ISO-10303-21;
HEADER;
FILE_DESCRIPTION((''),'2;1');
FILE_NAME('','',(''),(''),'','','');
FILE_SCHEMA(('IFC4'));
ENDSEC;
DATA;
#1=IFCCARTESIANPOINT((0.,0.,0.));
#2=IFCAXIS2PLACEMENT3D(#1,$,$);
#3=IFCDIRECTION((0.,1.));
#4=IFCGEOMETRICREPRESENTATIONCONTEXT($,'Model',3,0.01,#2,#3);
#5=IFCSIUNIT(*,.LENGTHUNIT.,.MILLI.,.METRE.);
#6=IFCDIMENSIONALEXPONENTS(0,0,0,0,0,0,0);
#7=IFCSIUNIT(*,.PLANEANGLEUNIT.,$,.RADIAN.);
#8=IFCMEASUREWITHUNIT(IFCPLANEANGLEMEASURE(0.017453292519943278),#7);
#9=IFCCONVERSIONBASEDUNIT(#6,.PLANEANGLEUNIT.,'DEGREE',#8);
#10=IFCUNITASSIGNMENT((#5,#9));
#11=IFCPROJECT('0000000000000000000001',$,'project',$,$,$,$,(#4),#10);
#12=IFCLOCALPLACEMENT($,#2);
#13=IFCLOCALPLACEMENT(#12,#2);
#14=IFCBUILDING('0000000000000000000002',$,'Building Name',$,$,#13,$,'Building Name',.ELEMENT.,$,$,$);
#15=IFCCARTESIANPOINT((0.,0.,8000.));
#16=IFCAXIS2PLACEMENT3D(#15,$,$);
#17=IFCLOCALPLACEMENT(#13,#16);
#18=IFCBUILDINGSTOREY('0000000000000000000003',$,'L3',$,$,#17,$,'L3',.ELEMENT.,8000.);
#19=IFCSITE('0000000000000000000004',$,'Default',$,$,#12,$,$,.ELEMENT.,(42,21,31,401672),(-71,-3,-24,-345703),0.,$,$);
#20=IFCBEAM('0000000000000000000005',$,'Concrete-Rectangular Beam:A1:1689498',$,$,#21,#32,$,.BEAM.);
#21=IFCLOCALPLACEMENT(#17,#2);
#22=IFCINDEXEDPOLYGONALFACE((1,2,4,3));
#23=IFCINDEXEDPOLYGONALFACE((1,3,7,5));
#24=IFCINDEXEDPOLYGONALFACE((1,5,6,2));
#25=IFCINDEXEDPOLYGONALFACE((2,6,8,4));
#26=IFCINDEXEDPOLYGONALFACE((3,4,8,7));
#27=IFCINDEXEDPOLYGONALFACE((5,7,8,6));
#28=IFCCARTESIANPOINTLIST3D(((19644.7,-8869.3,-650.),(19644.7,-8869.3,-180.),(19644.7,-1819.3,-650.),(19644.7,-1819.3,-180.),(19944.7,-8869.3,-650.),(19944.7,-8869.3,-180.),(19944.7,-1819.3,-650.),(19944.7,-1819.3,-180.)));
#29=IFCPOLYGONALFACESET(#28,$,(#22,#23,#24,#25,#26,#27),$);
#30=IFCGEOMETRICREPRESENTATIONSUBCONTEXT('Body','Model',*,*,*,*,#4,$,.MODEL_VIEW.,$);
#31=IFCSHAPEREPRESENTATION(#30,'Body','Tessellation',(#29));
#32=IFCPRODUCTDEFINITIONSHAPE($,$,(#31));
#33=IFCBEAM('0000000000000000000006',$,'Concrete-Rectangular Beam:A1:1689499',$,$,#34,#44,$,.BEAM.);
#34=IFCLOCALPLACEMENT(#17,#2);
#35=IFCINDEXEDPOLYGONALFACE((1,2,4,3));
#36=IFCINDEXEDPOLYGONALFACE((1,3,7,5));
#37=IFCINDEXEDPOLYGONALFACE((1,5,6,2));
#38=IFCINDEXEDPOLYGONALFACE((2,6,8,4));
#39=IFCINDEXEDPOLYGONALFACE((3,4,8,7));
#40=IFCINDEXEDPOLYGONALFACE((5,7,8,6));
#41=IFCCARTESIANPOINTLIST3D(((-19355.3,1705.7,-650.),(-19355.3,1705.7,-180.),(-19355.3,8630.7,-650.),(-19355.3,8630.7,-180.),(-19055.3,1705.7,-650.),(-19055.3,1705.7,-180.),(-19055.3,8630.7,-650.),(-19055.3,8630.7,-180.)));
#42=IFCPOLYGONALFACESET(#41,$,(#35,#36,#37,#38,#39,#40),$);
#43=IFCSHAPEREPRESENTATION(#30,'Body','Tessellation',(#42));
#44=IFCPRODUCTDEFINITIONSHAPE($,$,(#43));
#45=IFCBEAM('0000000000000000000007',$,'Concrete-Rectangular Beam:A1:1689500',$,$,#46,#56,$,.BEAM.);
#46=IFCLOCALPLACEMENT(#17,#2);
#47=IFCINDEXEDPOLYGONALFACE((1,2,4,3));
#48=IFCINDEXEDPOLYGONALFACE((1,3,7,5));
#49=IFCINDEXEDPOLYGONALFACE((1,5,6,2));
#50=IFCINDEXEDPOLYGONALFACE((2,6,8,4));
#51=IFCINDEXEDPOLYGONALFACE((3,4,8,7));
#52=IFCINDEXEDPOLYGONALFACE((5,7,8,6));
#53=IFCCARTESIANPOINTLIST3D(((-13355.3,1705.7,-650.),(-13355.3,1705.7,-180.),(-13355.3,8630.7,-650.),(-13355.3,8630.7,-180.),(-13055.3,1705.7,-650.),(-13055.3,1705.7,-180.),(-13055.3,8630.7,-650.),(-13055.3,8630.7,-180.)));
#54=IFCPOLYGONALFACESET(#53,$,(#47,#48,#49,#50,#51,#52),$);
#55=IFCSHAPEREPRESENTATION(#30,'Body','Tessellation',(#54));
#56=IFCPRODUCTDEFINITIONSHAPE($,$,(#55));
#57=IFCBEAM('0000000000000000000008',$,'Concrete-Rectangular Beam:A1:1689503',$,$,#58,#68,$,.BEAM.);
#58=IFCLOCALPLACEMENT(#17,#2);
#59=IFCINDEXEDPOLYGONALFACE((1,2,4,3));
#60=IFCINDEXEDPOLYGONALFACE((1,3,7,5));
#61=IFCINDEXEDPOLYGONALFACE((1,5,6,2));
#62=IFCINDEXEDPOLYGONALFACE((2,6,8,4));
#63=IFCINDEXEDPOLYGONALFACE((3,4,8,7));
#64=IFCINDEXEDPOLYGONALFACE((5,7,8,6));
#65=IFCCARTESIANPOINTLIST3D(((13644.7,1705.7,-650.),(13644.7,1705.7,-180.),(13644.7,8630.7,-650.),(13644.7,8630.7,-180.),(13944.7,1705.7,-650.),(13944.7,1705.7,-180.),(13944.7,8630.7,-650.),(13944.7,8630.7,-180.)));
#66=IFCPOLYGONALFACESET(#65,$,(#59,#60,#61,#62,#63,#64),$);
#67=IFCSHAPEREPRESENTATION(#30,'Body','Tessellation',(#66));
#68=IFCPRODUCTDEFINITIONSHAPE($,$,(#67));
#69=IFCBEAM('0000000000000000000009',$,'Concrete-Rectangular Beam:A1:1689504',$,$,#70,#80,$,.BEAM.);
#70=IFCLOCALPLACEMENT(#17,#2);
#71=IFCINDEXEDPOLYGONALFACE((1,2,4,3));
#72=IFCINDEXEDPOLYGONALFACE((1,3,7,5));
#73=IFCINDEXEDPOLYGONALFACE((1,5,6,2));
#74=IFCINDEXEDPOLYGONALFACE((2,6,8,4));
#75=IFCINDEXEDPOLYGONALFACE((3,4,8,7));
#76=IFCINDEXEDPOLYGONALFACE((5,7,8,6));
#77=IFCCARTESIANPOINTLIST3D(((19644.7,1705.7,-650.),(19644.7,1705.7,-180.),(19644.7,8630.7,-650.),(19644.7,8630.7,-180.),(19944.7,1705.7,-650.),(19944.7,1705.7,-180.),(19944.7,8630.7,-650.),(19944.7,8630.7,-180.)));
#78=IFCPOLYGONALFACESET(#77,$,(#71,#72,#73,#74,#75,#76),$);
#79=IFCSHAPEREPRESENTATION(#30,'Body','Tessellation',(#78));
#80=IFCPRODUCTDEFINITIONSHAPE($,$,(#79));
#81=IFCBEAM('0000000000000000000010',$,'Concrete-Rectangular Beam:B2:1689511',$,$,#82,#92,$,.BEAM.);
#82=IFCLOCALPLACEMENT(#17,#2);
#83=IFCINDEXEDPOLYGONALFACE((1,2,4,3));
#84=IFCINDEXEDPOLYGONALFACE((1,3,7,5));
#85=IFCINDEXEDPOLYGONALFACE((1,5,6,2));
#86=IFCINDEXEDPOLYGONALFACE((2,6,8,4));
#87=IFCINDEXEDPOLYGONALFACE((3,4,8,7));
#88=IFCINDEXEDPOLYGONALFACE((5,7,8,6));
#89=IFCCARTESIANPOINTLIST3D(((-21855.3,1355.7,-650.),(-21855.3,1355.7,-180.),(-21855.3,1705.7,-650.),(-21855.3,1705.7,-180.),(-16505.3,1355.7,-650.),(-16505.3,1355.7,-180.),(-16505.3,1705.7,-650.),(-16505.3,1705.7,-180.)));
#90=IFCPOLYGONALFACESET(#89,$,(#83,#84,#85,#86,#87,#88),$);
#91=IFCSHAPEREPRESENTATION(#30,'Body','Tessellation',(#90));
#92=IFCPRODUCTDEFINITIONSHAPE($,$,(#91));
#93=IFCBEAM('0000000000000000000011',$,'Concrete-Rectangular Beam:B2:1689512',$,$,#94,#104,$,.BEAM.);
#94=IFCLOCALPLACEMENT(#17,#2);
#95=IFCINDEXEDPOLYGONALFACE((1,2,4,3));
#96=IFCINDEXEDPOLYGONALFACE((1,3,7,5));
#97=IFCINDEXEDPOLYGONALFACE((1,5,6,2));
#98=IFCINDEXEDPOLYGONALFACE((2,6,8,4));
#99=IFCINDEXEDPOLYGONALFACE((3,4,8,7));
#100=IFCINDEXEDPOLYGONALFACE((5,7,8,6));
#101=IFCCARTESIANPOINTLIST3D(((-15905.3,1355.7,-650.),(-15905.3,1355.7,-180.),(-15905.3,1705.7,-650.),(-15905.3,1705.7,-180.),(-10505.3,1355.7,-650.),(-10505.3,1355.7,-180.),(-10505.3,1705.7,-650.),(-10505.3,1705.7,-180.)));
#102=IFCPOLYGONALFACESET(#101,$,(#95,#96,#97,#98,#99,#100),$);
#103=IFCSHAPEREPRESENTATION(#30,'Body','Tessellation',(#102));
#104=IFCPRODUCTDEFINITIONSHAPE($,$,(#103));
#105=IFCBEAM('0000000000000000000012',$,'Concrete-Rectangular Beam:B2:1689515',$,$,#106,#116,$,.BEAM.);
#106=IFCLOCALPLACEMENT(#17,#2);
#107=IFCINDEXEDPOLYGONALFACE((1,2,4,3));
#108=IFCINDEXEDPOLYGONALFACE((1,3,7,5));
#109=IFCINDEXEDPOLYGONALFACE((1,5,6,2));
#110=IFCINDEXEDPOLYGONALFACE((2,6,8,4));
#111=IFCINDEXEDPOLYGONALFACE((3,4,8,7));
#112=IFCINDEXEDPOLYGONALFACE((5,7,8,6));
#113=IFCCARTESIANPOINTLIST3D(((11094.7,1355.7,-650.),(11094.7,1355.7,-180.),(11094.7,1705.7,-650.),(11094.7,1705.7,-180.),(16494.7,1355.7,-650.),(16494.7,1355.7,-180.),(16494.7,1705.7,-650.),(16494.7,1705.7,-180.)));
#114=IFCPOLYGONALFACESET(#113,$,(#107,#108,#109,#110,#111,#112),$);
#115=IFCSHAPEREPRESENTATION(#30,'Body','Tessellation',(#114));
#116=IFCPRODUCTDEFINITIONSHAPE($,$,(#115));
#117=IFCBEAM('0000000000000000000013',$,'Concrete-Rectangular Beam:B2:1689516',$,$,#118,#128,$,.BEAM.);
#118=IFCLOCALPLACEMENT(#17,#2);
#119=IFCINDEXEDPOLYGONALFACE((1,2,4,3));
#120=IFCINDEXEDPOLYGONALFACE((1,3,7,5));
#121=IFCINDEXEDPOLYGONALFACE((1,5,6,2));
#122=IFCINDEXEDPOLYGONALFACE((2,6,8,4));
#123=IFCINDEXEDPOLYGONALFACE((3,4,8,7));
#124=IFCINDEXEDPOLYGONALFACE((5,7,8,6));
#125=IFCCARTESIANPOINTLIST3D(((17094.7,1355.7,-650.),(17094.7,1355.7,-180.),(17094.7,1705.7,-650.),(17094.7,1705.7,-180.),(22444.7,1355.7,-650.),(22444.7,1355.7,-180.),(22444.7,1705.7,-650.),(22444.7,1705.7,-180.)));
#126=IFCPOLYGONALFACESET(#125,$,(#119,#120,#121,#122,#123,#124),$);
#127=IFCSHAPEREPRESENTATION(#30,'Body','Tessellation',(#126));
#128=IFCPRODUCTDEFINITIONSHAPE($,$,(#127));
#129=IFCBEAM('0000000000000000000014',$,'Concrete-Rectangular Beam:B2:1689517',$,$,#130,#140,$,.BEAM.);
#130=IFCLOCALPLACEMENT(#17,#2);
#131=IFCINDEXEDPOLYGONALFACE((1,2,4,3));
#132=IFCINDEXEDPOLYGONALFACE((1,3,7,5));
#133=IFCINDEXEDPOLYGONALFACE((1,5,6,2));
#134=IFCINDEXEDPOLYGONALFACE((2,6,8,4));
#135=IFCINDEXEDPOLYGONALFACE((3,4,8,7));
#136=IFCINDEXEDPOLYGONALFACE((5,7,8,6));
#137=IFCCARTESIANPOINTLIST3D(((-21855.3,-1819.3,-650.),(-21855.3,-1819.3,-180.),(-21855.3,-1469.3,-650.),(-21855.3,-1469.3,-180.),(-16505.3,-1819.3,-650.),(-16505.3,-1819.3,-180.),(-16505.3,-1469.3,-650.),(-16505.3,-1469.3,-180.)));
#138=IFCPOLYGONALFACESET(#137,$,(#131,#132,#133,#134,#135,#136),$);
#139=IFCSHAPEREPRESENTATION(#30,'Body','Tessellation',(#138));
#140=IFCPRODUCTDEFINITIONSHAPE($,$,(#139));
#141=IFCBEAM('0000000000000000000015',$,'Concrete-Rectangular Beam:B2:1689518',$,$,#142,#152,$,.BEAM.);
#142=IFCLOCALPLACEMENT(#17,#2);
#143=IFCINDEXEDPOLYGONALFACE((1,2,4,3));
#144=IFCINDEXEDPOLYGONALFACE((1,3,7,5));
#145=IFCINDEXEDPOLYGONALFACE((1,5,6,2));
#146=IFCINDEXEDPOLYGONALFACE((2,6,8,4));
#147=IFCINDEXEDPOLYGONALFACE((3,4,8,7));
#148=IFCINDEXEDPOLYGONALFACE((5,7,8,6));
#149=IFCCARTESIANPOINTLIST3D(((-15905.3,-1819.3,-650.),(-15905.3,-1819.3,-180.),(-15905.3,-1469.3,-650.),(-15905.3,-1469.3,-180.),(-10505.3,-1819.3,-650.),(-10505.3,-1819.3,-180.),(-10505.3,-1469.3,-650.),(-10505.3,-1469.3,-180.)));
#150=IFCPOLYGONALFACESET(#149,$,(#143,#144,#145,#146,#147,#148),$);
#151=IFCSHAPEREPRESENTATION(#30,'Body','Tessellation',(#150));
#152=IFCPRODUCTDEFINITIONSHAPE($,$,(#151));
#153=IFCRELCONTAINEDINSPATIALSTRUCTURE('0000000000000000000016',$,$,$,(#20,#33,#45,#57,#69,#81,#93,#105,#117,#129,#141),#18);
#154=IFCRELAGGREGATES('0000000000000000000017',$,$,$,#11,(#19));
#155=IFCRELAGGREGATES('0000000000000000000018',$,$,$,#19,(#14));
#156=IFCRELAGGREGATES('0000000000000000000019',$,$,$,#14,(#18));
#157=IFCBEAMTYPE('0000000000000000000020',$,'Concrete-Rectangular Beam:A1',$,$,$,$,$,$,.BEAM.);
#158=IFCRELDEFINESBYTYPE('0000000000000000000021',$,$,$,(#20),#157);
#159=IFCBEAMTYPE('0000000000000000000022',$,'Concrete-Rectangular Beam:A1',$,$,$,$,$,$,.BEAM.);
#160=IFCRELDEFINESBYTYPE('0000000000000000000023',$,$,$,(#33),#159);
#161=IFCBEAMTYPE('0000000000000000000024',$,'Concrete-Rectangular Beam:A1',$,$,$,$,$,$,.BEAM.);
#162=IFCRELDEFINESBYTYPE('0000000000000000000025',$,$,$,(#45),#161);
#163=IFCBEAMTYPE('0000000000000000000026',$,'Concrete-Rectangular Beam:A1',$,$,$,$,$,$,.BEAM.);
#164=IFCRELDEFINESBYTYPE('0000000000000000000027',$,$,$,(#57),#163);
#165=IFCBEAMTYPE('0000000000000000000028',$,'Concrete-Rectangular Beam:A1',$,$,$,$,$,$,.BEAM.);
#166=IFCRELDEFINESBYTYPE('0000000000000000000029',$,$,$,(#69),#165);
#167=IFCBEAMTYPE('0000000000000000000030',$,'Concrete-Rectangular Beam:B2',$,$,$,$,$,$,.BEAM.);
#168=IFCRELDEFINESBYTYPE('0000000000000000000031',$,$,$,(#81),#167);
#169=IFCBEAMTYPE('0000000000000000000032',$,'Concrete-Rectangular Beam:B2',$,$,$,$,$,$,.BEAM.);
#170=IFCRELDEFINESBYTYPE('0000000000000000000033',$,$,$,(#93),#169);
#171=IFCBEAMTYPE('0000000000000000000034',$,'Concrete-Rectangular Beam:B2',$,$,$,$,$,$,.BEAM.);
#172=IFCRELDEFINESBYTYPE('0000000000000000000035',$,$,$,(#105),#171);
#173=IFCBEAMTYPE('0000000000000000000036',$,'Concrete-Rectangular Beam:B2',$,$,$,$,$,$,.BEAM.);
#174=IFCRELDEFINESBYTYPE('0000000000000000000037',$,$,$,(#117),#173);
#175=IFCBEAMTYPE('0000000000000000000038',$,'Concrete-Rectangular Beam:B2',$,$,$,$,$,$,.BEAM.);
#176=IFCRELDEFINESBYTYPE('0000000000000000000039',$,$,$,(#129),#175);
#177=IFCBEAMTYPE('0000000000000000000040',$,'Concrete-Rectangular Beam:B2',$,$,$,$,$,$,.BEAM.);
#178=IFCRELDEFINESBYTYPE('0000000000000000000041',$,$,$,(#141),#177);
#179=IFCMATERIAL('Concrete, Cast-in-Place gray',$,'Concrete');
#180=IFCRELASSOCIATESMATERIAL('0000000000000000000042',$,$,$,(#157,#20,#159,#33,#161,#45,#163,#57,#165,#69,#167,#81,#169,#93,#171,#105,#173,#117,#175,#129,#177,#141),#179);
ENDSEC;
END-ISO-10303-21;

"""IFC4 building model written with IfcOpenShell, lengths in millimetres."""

from ifc_helpers import new_model, entity, si_unit, converted_unit, direction, frame, origin, place, context, subcontext, project, spatial, indexed_curve, outline, extrude, source, transform, mapped, material, type_object, type_shapes, element, save


model = new_model("IFC4")

# Units and contexts
model_context = context("Model", 3, precision=0.01, world=origin(), true_north=direction((0.0, 1.0)))
body_context = subcontext(model_context, "Body", "Model", "MODEL_VIEW")
ifc_project = project(units=[si_unit("LENGTHUNIT", "METRE", prefix="MILLI"), converted_unit("PLANEANGLEUNIT", "DEGREE", entity("IfcPlaneAngleMeasure", 0.017453292519943278), si_unit("PLANEANGLEUNIT", "RADIAN"), dimensions=[0, 0, 0, 0, 0, 0, 0])], contexts=[model_context])

# Site, building, storey
site_placement = place(None, origin())
site = spatial("IfcSite", under=ifc_project, at=site_placement, Name="Default", CompositionType="ELEMENT", RefLatitude=(42, 21, 31, 401672), RefLongitude=(-71, -3, -24, -345703), RefElevation=0.0)
building_placement = place(site_placement, origin())
building = spatial("IfcBuilding", under=site, at=building_placement, Name="Building Name", LongName="Building Name", CompositionType="ELEMENT")
storey_placement = place(building_placement, frame((0.0, 0.0, 8000.0)))
storey = spatial("IfcBuildingStorey", under=building, at=storey_placement, Name="L3", LongName="L3", CompositionType="ELEMENT", Elevation=8000.0)

# Beams
ifc_material = material(Name="Concrete, Cast-in-Place gray", Category="Concrete")
beam_type_1 = type_object("IfcBeamType", Name="Concrete-Rectangular Beam:A1", PredefinedType="BEAM", material=ifc_material)
shared_shape_1 = source(origin(), body_context, "Body", "SweptSolid", [
    extrude(outline(indexed_curve([(-150.0, -235.0), (150.0, -235.0), (150.0, 235.0), (-150.0, 235.0), (-150.0, -235.0)], self_intersect=False)), frame((19794.7, -8869.3, 7585.0), z_axis=(0.0, 1.0, 0.0), x_axis=(-1.0, 0.0, 0.0)), (0.0, 0.0, 1.0), 7050.0),
])
type_shapes(beam_type_1, [shared_shape_1])
beam_1_placement = place(storey_placement, frame((0.0, 0.0, -8000.0)))
element("IfcBeam", 1, at=beam_1_placement, inside=storey, type_object=beam_type_1, material=ifc_material, Name="Concrete-Rectangular Beam:A1:1689498", PredefinedType="BEAM", context=body_context, shape_type="MappedRepresentation", body=[
    mapped(shared_shape_1, transform((0.0, 0.0, 0.0), scale=1.0)),
])
beam_type_2 = type_object("IfcBeamType", Name="Concrete-Rectangular Beam:A1", PredefinedType="BEAM", material=ifc_material)
shared_shape_2 = source(origin(), body_context, "Body", "SweptSolid", [
    extrude(outline(indexed_curve([(-150.0, -235.0), (150.0, -235.0), (150.0, 235.0), (-150.0, 235.0), (-150.0, -235.0)], self_intersect=False)), frame((-19205.3, 8630.7, 7585.0), z_axis=(0.0, -1.0, 0.0), x_axis=(-1.0, 0.0, 0.0)), (0.0, 0.0, 1.0), 6925.0),
])
type_shapes(beam_type_2, [shared_shape_2])
beam_2_placement = place(storey_placement, frame((0.0, 0.0, -8000.0)))
element("IfcBeam", 2, at=beam_2_placement, inside=storey, type_object=beam_type_2, material=ifc_material, Name="Concrete-Rectangular Beam:A1:1689499", PredefinedType="BEAM", context=body_context, shape_type="MappedRepresentation", body=[
    mapped(shared_shape_2, transform((0.0, 0.0, 0.0), scale=1.0)),
])
beam_type_3 = type_object("IfcBeamType", Name="Concrete-Rectangular Beam:A1", PredefinedType="BEAM", material=ifc_material)
shared_shape_3 = source(origin(), body_context, "Body", "SweptSolid", [
    extrude(outline(indexed_curve([(-150.0, -235.0), (150.0, -235.0), (150.0, 235.0), (-150.0, 235.0), (-150.0, -235.0)], self_intersect=False)), frame((-13205.3, 8630.7, 7585.0), z_axis=(0.0, -1.0, 0.0), x_axis=(-1.0, 0.0, 0.0)), (0.0, 0.0, 1.0), 6925.0),
])
type_shapes(beam_type_3, [shared_shape_3])
beam_3_placement = place(storey_placement, frame((0.0, 0.0, -8000.0)))
element("IfcBeam", 3, at=beam_3_placement, inside=storey, type_object=beam_type_3, material=ifc_material, Name="Concrete-Rectangular Beam:A1:1689500", PredefinedType="BEAM", context=body_context, shape_type="MappedRepresentation", body=[
    mapped(shared_shape_3, transform((0.0, 0.0, 0.0), scale=1.0)),
])
beam_type_4 = type_object("IfcBeamType", Name="Concrete-Rectangular Beam:A1", PredefinedType="BEAM", material=ifc_material)
shared_shape_4 = source(origin(), body_context, "Body", "SweptSolid", [
    extrude(outline(indexed_curve([(-150.0, -235.0), (150.0, -235.0), (150.0, 235.0), (-150.0, 235.0), (-150.0, -235.0)], self_intersect=False)), frame((13794.7, 8630.7, 7585.0), z_axis=(0.0, -1.0, 0.0), x_axis=(-1.0, 0.0, 0.0)), (0.0, 0.0, 1.0), 6925.0),
])
type_shapes(beam_type_4, [shared_shape_4])
beam_4_placement = place(storey_placement, frame((0.0, 0.0, -8000.0)))
element("IfcBeam", 4, at=beam_4_placement, inside=storey, type_object=beam_type_4, material=ifc_material, Name="Concrete-Rectangular Beam:A1:1689503", PredefinedType="BEAM", context=body_context, shape_type="MappedRepresentation", body=[
    mapped(shared_shape_4, transform((0.0, 0.0, 0.0), scale=1.0)),
])
beam_type_5 = type_object("IfcBeamType", Name="Concrete-Rectangular Beam:A1", PredefinedType="BEAM", material=ifc_material)
shared_shape_5 = source(origin(), body_context, "Body", "SweptSolid", [
    extrude(outline(indexed_curve([(-150.0, -235.0), (150.0, -235.0), (150.0, 235.0), (-150.0, 235.0), (-150.0, -235.0)], self_intersect=False)), frame((19794.7, 8630.7, 7585.0), z_axis=(0.0, -1.0, 0.0), x_axis=(-1.0, 0.0, 0.0)), (0.0, 0.0, 1.0), 6925.0),
])
type_shapes(beam_type_5, [shared_shape_5])
beam_5_placement = place(storey_placement, frame((0.0, 0.0, -8000.0)))
element("IfcBeam", 5, at=beam_5_placement, inside=storey, type_object=beam_type_5, material=ifc_material, Name="Concrete-Rectangular Beam:A1:1689504", PredefinedType="BEAM", context=body_context, shape_type="MappedRepresentation", body=[
    mapped(shared_shape_5, transform((0.0, 0.0, 0.0), scale=1.0)),
])
beam_type_6 = type_object("IfcBeamType", Name="Concrete-Rectangular Beam:B2", PredefinedType="BEAM", material=ifc_material)
shared_shape_6 = source(origin(), body_context, "Body", "SweptSolid", [
    extrude(outline(indexed_curve([(-235.0, -175.0), (235.0, -175.0), (235.0, 175.0), (-235.0, 175.0), (-235.0, -175.0)], self_intersect=False)), frame((-21855.3, 1530.7, 7585.0), z_axis=(1.0, 0.0, 0.0), x_axis=(0.0, 0.0, -1.0)), (0.0, 0.0, 1.0), 5350.0),
])
type_shapes(beam_type_6, [shared_shape_6])
beam_6_placement = place(storey_placement, frame((0.0, 0.0, -8000.0)))
element("IfcBeam", 6, at=beam_6_placement, inside=storey, type_object=beam_type_6, material=ifc_material, Name="Concrete-Rectangular Beam:B2:1689511", PredefinedType="BEAM", context=body_context, shape_type="MappedRepresentation", body=[
    mapped(shared_shape_6, transform((0.0, 0.0, 0.0), scale=1.0)),
])
beam_type_7 = type_object("IfcBeamType", Name="Concrete-Rectangular Beam:B2", PredefinedType="BEAM", material=ifc_material)
shared_shape_7 = source(origin(), body_context, "Body", "SweptSolid", [
    extrude(outline(indexed_curve([(-235.0, -175.0), (235.0, -175.0), (235.0, 175.0), (-235.0, 175.0), (-235.0, -175.0)], self_intersect=False)), frame((-15905.3, 1530.7, 7585.0), z_axis=(1.0, 0.0, 0.0), x_axis=(0.0, 0.0, -1.0)), (0.0, 0.0, 1.0), 5400.0),
])
type_shapes(beam_type_7, [shared_shape_7])
beam_7_placement = place(storey_placement, frame((0.0, 0.0, -8000.0)))
element("IfcBeam", 7, at=beam_7_placement, inside=storey, type_object=beam_type_7, material=ifc_material, Name="Concrete-Rectangular Beam:B2:1689512", PredefinedType="BEAM", context=body_context, shape_type="MappedRepresentation", body=[
    mapped(shared_shape_7, transform((0.0, 0.0, 0.0), scale=1.0)),
])
beam_type_8 = type_object("IfcBeamType", Name="Concrete-Rectangular Beam:B2", PredefinedType="BEAM", material=ifc_material)
shared_shape_8 = source(origin(), body_context, "Body", "SweptSolid", [
    extrude(outline(indexed_curve([(-235.0, -175.0), (235.0, -175.0), (235.0, 175.0), (-235.0, 175.0), (-235.0, -175.0)], self_intersect=False)), frame((11094.7, 1530.7, 7585.0), z_axis=(1.0, 0.0, 0.0), x_axis=(0.0, 0.0, -1.0)), (0.0, 0.0, 1.0), 5400.0),
])
type_shapes(beam_type_8, [shared_shape_8])
beam_8_placement = place(storey_placement, frame((0.0, 0.0, -8000.0)))
element("IfcBeam", 8, at=beam_8_placement, inside=storey, type_object=beam_type_8, material=ifc_material, Name="Concrete-Rectangular Beam:B2:1689515", PredefinedType="BEAM", context=body_context, shape_type="MappedRepresentation", body=[
    mapped(shared_shape_8, transform((0.0, 0.0, 0.0), scale=1.0)),
])
beam_type_9 = type_object("IfcBeamType", Name="Concrete-Rectangular Beam:B2", PredefinedType="BEAM", material=ifc_material)
shared_shape_9 = source(origin(), body_context, "Body", "SweptSolid", [
    extrude(outline(indexed_curve([(-235.0, -175.0), (235.0, -175.0), (235.0, 175.0), (-235.0, 175.0), (-235.0, -175.0)], self_intersect=False)), frame((17094.7, 1530.7, 7585.0), z_axis=(1.0, 0.0, 0.0), x_axis=(0.0, 0.0, -1.0)), (0.0, 0.0, 1.0), 5350.0),
])
type_shapes(beam_type_9, [shared_shape_9])
beam_9_placement = place(storey_placement, frame((0.0, 0.0, -8000.0)))
element("IfcBeam", 9, at=beam_9_placement, inside=storey, type_object=beam_type_9, material=ifc_material, Name="Concrete-Rectangular Beam:B2:1689516", PredefinedType="BEAM", context=body_context, shape_type="MappedRepresentation", body=[
    mapped(shared_shape_9, transform((0.0, 0.0, 0.0), scale=1.0)),
])
beam_type_10 = type_object("IfcBeamType", Name="Concrete-Rectangular Beam:B2", PredefinedType="BEAM", material=ifc_material)
shared_shape_10 = source(origin(), body_context, "Body", "SweptSolid", [
    extrude(outline(indexed_curve([(-235.0, -175.0), (235.0, -175.0), (235.0, 175.0), (-235.0, 175.0), (-235.0, -175.0)], self_intersect=False)), frame((-21855.3, -1644.3, 7585.0), z_axis=(1.0, 0.0, 0.0), x_axis=(0.0, 0.0, -1.0)), (0.0, 0.0, 1.0), 5350.0),
])
type_shapes(beam_type_10, [shared_shape_10])
beam_10_placement = place(storey_placement, frame((0.0, 0.0, -8000.0)))
element("IfcBeam", 10, at=beam_10_placement, inside=storey, type_object=beam_type_10, material=ifc_material, Name="Concrete-Rectangular Beam:B2:1689517", PredefinedType="BEAM", context=body_context, shape_type="MappedRepresentation", body=[
    mapped(shared_shape_10, transform((0.0, 0.0, 0.0), scale=1.0)),
])
beam_type_11 = type_object("IfcBeamType", Name="Concrete-Rectangular Beam:B2", PredefinedType="BEAM", material=ifc_material)
shared_shape_11 = source(origin(), body_context, "Body", "SweptSolid", [
    extrude(outline(indexed_curve([(-235.0, -175.0), (235.0, -175.0), (235.0, 175.0), (-235.0, 175.0), (-235.0, -175.0)], self_intersect=False)), frame((-15905.3, -1644.3, 7585.0), z_axis=(1.0, 0.0, 0.0), x_axis=(0.0, 0.0, -1.0)), (0.0, 0.0, 1.0), 5400.0),
])
type_shapes(beam_type_11, [shared_shape_11])
beam_11_placement = place(storey_placement, frame((0.0, 0.0, -8000.0)))
element("IfcBeam", 11, at=beam_11_placement, inside=storey, type_object=beam_type_11, material=ifc_material, Name="Concrete-Rectangular Beam:B2:1689518", PredefinedType="BEAM", context=body_context, shape_type="MappedRepresentation", body=[
    mapped(shared_shape_11, transform((0.0, 0.0, 0.0), scale=1.0)),
])

save(model, "model.ifc")
